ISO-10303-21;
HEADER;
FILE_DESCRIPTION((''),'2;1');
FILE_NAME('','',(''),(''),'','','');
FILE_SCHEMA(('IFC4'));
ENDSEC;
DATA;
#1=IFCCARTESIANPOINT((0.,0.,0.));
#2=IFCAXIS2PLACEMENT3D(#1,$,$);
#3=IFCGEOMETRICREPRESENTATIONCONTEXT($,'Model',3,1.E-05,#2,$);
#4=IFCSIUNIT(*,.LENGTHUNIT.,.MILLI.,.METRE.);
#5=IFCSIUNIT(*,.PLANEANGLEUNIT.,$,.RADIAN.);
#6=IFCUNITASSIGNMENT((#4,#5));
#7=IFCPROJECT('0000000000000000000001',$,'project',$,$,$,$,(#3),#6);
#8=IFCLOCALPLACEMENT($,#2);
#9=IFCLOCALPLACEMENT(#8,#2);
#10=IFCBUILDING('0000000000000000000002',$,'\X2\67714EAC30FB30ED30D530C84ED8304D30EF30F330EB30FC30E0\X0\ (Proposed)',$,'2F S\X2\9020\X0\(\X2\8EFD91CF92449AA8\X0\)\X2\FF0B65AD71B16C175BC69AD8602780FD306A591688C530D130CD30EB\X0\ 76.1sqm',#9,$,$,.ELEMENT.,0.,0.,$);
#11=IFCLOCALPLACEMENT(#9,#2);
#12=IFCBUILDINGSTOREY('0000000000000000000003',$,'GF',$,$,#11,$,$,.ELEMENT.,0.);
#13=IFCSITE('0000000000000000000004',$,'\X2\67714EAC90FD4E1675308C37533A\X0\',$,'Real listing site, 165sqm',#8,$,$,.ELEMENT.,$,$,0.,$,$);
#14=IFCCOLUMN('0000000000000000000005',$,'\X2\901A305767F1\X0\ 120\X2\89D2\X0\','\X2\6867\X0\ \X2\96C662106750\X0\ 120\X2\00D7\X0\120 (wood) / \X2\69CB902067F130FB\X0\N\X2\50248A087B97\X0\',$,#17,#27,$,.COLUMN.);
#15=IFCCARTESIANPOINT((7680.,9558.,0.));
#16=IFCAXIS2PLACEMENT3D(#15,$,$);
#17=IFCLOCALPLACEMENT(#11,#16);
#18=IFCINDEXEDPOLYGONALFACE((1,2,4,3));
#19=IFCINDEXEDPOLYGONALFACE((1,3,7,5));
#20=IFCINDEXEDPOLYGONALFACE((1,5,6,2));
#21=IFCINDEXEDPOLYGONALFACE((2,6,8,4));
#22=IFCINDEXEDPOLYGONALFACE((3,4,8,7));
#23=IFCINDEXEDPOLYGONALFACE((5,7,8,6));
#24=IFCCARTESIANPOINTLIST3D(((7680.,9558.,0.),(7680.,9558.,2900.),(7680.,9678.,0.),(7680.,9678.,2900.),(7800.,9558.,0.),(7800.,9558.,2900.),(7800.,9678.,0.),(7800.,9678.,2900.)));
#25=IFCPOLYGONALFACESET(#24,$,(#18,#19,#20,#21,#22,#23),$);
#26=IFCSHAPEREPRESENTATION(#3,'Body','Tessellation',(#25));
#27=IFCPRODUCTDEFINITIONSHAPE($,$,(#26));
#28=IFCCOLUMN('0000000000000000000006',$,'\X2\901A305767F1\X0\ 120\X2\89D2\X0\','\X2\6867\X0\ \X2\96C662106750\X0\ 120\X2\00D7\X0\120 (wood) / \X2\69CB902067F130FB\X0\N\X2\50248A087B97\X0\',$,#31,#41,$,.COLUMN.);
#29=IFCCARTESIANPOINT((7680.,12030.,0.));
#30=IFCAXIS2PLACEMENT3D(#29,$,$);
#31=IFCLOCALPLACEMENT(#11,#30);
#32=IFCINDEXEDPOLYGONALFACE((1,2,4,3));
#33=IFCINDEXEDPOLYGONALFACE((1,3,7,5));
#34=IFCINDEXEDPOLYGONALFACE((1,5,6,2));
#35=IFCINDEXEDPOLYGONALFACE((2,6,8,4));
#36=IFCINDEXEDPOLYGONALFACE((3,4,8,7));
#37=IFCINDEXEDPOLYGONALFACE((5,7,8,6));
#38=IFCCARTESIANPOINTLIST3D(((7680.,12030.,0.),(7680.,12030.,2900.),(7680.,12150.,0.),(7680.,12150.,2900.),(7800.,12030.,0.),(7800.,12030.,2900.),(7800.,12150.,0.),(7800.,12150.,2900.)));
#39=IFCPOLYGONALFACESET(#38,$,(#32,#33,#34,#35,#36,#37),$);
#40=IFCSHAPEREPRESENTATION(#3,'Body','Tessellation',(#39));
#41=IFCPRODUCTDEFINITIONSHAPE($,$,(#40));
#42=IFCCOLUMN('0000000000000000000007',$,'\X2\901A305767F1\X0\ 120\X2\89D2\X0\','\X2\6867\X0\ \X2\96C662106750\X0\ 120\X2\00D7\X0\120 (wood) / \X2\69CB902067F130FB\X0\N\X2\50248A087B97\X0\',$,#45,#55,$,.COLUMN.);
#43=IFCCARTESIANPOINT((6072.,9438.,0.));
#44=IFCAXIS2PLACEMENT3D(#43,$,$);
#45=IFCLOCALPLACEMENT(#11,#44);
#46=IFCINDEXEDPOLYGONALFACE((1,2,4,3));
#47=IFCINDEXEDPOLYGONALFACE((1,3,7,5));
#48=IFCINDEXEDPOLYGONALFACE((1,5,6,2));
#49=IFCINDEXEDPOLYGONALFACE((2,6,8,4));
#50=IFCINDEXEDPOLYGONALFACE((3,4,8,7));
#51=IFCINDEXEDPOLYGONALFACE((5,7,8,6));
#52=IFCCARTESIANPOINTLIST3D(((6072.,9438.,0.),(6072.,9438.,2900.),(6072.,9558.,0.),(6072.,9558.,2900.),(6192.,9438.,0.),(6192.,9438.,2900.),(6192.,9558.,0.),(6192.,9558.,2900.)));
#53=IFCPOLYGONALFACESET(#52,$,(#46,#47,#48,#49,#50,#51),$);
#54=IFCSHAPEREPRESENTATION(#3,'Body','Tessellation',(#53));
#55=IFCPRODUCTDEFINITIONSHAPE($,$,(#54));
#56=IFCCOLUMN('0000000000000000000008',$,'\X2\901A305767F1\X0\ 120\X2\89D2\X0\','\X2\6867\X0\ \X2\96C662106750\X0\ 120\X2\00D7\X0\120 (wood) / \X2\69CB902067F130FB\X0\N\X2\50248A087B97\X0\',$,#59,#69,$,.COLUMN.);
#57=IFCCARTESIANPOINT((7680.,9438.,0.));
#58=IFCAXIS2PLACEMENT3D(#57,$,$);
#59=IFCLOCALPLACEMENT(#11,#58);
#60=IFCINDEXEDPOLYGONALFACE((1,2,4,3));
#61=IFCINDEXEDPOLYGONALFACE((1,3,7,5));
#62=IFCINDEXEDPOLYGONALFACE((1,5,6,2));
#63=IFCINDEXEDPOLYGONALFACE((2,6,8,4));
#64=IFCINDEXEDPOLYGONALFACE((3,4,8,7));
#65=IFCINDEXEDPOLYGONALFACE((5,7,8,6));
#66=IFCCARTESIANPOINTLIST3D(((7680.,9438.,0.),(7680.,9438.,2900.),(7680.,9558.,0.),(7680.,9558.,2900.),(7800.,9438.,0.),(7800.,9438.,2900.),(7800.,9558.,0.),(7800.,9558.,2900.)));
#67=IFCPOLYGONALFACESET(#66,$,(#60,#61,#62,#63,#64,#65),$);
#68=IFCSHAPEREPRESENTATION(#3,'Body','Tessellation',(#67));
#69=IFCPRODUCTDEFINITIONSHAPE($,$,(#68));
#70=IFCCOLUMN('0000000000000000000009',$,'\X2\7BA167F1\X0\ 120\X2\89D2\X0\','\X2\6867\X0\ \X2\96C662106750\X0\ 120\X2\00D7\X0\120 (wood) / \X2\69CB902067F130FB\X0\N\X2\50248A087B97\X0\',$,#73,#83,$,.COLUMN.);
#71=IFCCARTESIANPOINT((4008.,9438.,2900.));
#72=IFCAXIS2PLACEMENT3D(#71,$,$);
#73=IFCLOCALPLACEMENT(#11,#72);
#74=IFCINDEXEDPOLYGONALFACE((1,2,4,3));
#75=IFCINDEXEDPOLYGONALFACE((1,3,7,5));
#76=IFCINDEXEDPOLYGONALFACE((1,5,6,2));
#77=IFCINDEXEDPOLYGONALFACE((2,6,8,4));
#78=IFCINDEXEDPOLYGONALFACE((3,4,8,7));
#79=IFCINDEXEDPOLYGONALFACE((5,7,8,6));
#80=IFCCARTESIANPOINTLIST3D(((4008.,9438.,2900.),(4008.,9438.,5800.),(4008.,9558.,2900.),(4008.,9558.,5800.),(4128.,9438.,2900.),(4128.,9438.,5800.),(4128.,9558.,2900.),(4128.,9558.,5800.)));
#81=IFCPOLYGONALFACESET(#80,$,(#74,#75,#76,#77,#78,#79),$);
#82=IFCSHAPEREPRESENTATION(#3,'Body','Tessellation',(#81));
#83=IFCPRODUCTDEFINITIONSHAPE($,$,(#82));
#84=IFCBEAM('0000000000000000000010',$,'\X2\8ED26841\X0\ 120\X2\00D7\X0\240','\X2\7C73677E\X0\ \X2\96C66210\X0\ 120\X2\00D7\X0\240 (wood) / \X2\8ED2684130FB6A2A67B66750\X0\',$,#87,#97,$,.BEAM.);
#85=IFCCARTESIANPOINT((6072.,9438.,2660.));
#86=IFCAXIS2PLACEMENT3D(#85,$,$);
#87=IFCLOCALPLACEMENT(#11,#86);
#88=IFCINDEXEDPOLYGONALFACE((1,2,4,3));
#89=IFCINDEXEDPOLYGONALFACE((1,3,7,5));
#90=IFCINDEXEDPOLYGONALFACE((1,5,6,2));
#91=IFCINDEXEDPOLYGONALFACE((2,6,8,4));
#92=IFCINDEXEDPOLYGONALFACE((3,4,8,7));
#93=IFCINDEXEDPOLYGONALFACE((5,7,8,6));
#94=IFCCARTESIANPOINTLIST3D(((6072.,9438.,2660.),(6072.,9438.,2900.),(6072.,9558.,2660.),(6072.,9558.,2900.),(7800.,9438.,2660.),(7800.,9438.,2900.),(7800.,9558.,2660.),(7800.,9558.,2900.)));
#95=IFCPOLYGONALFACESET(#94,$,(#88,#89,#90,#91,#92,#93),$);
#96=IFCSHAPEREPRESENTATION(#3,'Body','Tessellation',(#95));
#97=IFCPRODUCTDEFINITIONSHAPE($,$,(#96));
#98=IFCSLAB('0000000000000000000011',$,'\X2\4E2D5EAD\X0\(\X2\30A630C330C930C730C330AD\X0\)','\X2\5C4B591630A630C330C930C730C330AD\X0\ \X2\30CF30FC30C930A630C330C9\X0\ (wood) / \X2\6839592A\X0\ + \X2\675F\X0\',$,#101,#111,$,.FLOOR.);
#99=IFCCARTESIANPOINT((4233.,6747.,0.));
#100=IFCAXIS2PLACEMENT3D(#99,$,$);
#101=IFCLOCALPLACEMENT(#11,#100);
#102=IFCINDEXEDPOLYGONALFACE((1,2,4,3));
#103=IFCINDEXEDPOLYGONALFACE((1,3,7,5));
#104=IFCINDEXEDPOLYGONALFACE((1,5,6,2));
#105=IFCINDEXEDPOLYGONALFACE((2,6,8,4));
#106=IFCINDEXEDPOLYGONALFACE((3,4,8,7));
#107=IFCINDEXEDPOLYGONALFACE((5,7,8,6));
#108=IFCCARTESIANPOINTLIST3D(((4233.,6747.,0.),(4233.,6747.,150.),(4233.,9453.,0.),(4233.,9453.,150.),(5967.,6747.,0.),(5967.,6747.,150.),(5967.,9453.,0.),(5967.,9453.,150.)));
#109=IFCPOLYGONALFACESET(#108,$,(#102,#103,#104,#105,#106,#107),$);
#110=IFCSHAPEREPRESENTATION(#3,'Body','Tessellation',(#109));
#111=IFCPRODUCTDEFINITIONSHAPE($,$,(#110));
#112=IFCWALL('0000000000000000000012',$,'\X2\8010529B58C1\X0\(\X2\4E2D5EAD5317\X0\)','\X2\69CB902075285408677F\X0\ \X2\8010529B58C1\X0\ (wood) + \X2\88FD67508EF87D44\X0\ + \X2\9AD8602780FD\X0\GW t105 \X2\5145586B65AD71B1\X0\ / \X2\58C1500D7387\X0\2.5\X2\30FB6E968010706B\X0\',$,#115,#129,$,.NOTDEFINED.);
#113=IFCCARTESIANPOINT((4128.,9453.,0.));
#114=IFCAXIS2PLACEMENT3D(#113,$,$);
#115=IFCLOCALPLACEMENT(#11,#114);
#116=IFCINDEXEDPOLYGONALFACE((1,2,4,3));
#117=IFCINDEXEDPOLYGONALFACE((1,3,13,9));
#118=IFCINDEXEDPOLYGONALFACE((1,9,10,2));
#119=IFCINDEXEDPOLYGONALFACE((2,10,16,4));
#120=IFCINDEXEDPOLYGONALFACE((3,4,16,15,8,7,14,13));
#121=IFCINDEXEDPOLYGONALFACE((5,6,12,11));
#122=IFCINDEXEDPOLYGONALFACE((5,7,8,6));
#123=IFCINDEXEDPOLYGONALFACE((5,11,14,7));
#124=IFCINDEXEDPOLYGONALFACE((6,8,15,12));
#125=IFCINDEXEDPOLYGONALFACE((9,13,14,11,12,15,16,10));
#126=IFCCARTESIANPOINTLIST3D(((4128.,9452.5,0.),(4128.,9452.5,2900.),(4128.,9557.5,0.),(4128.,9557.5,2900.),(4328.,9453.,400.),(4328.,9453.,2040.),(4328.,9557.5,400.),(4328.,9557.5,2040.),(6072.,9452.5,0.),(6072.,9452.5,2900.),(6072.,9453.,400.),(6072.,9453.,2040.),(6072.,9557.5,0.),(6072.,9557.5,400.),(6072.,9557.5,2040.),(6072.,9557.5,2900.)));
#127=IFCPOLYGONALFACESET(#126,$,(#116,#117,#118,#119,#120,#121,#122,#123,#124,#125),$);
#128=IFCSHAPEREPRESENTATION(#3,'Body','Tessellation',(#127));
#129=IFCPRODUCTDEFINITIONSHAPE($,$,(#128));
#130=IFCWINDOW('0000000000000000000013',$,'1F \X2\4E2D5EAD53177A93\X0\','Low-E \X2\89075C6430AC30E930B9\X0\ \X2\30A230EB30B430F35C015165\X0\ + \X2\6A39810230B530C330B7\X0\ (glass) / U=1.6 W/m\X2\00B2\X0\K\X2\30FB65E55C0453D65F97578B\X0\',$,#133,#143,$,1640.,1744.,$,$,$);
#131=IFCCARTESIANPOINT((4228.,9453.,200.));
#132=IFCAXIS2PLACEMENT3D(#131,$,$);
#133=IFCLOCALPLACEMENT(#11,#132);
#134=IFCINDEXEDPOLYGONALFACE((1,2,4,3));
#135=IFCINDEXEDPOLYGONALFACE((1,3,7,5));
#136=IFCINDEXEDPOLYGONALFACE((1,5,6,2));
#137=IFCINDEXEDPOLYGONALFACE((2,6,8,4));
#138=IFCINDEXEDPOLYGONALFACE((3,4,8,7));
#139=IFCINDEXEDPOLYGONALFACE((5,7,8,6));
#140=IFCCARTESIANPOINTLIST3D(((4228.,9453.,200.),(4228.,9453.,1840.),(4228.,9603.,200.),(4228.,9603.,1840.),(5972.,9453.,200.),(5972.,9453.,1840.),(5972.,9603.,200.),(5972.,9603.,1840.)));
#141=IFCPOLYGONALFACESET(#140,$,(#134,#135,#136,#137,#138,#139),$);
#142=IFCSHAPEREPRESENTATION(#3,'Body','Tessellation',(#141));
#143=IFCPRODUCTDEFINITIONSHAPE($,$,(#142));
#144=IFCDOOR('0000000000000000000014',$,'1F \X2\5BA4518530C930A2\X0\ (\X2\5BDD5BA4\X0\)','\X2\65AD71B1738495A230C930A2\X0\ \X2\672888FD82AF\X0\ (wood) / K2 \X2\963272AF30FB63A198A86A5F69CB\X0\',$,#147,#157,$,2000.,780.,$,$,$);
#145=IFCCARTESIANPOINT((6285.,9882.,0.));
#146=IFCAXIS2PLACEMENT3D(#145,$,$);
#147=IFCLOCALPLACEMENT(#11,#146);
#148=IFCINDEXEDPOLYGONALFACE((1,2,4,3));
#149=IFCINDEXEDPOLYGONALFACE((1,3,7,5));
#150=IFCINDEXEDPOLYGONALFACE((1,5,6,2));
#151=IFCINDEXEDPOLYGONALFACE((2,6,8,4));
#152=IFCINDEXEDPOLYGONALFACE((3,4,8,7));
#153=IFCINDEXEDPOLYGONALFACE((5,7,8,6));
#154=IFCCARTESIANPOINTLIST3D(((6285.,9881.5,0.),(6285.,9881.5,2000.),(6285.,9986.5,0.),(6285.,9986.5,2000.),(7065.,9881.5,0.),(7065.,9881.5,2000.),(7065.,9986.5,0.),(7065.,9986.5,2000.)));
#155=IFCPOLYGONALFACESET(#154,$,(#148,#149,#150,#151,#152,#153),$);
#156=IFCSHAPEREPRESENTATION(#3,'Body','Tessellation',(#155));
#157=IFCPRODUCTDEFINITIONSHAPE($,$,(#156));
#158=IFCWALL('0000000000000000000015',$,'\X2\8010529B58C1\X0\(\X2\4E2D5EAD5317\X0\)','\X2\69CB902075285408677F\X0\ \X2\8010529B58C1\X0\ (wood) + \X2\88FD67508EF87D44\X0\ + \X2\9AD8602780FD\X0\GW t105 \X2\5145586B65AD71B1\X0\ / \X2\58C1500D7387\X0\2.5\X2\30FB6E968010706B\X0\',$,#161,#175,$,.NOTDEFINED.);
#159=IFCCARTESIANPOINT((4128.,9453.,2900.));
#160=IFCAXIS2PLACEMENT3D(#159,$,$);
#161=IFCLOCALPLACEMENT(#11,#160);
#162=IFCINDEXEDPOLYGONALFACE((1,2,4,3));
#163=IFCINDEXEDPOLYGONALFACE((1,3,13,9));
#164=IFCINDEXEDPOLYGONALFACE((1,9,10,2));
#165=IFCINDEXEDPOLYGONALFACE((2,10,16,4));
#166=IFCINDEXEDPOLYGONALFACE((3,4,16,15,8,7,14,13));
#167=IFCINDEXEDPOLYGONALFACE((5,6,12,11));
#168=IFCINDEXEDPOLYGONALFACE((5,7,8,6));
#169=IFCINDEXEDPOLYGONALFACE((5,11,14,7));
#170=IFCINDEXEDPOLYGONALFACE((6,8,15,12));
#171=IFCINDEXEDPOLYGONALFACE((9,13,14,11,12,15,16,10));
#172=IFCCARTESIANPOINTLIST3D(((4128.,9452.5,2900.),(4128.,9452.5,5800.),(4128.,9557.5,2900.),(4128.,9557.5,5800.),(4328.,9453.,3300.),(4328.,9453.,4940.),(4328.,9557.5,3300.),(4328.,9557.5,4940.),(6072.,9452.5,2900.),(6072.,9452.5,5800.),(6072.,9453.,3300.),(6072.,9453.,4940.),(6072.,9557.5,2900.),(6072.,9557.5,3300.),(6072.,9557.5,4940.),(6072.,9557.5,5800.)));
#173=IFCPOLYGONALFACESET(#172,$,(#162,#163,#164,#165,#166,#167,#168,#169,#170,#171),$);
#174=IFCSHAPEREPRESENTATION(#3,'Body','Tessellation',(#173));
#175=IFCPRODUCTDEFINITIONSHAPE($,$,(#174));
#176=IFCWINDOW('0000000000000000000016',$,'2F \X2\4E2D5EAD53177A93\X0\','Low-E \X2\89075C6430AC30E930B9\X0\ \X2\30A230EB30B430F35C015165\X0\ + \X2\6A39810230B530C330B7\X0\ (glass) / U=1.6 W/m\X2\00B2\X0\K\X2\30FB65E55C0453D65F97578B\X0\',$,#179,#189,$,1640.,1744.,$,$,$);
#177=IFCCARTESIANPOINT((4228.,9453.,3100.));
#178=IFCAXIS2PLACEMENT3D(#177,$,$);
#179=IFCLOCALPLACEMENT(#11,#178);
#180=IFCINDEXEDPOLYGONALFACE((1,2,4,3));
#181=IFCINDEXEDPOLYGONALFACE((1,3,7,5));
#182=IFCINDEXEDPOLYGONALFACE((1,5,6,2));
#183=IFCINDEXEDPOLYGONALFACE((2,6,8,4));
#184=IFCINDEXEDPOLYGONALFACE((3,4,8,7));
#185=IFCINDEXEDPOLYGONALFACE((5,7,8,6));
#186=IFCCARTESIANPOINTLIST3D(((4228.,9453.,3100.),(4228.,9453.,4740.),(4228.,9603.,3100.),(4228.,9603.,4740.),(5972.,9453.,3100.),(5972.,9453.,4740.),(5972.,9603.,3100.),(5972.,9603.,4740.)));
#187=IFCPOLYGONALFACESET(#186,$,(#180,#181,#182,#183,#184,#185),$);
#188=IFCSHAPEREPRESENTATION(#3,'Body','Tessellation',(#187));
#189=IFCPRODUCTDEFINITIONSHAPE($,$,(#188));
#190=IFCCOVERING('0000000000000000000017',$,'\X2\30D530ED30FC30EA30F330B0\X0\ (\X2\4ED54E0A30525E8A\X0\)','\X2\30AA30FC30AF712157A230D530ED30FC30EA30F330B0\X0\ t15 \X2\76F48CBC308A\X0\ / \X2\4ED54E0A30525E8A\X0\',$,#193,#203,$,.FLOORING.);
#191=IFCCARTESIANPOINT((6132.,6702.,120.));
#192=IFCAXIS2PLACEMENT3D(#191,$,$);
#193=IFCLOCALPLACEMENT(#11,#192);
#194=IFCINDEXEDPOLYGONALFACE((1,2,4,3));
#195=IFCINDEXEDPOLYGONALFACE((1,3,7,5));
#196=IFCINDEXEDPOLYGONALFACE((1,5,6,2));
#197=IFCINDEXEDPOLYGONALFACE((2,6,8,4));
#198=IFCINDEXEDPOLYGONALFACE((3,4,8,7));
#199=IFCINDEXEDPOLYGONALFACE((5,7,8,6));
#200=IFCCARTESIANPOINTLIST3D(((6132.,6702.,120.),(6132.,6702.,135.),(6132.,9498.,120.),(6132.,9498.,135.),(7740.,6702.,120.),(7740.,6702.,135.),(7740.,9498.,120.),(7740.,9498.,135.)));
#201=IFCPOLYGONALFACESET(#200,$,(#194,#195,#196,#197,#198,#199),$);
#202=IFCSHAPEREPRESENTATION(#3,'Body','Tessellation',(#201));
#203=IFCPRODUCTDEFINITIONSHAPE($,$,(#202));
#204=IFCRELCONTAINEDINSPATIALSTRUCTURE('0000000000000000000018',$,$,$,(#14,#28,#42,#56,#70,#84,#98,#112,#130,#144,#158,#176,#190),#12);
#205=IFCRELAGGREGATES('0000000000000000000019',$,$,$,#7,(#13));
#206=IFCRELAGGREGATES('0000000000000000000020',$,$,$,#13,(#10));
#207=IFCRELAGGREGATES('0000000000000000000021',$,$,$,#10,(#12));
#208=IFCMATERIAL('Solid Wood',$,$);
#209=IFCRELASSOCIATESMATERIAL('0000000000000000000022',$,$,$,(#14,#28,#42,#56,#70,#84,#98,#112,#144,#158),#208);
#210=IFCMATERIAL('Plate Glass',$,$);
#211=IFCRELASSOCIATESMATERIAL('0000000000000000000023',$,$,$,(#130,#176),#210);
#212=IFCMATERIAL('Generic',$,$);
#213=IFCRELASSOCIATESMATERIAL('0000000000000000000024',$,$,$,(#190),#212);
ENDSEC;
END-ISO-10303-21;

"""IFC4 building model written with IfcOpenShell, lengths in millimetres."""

from ifc_helpers import new_model, si_unit, frame, frame_2d, origin, place, context, project, spatial, rectangle, extrude, material, element, fill, save


model = new_model("IFC4")

# Units and contexts
model_context = context("Model", 3, precision=1e-05, world=origin())
ifc_project = project(units=[si_unit("LENGTHUNIT", "METRE", prefix="MILLI"), si_unit("PLANEANGLEUNIT", "RADIAN")], contexts=[model_context])

# Site, building, storey
site_placement = place(None, origin())
site = spatial("IfcSite", under=ifc_project, at=site_placement, Name="東京都世田谷区", ObjectType="Real listing site, 165sqm", CompositionType="ELEMENT", RefElevation=0.0)
building_placement = place(site_placement, origin())
building = spatial("IfcBuilding", under=site, at=building_placement, Name="東京・ロフト付きワンルーム (Proposed)", ObjectType="2F S造(軽量鉄骨)＋断熱気密高性能な外装パネル 76.1sqm", CompositionType="ELEMENT", ElevationOfRefHeight=0.0, ElevationOfTerrain=0.0)
storey_placement = place(building_placement, origin())
storey = spatial("IfcBuildingStorey", under=building, at=storey_placement, Name="GF", CompositionType="ELEMENT", Elevation=0.0)

# Columns
ifc_material_1 = material(Name="Solid Wood")
column_1_placement = place(storey_placement, frame((7680.0, 9558.0, 0.0)))
element("IfcColumn", 1, at=column_1_placement, inside=storey, material=ifc_material_1, Name="通し柱 120角", Description="桧 集成材 120×120 (wood) / 構造柱・N値計算", PredefinedType="COLUMN", context=model_context, shape_type="SweptSolid", body=[
    extrude(rectangle(XDim=120.0, YDim=120.0, at=frame_2d((60.0, 60.0))), frame((7680.0, 9558.0, 0.0)), (0.0, 0.0, 1.0), 2900.0),
])
column_2_placement = place(storey_placement, frame((7680.0, 12030.0, 0.0)))
element("IfcColumn", 2, at=column_2_placement, inside=storey, material=ifc_material_1, Name="通し柱 120角", Description="桧 集成材 120×120 (wood) / 構造柱・N値計算", PredefinedType="COLUMN", context=model_context, shape_type="SweptSolid", body=[
    extrude(rectangle(XDim=120.0, YDim=120.0, at=frame_2d((60.0, 60.0))), frame((7680.0, 12030.0, 0.0)), (0.0, 0.0, 1.0), 2900.0),
])
column_3_placement = place(storey_placement, frame((6072.0, 9438.0, 0.0)))
element("IfcColumn", 3, at=column_3_placement, inside=storey, material=ifc_material_1, Name="通し柱 120角", Description="桧 集成材 120×120 (wood) / 構造柱・N値計算", PredefinedType="COLUMN", context=model_context, shape_type="SweptSolid", body=[
    extrude(rectangle(XDim=120.0, YDim=120.0, at=frame_2d((60.0, 60.0))), frame((6072.0, 9438.0, 0.0)), (0.0, 0.0, 1.0), 2900.0),
])
column_4_placement = place(storey_placement, frame((7680.0, 9438.0, 0.0)))
element("IfcColumn", 4, at=column_4_placement, inside=storey, material=ifc_material_1, Name="通し柱 120角", Description="桧 集成材 120×120 (wood) / 構造柱・N値計算", PredefinedType="COLUMN", context=model_context, shape_type="SweptSolid", body=[
    extrude(rectangle(XDim=120.0, YDim=120.0, at=frame_2d((60.0, 60.0))), frame((7680.0, 9438.0, 0.0)), (0.0, 0.0, 1.0), 2900.0),
])
column_5_placement = place(storey_placement, frame((4008.0, 9438.0, 2900.0)))
element("IfcColumn", 5, at=column_5_placement, inside=storey, material=ifc_material_1, Name="管柱 120角", Description="桧 集成材 120×120 (wood) / 構造柱・N値計算", PredefinedType="COLUMN", context=model_context, shape_type="SweptSolid", body=[
    extrude(rectangle(XDim=120.0, YDim=120.0, at=frame_2d((60.0, 60.0))), frame((4008.0, 9438.0, 2900.0)), (0.0, 0.0, 1.0), 2900.0),
])

# Beam
beam_1_placement = place(storey_placement, frame((6072.0, 9438.0, 2660.0)))
element("IfcBeam", 6, at=beam_1_placement, inside=storey, material=ifc_material_1, Name="軒桁 120×240", Description="米松 集成 120×240 (wood) / 軒桁・横架材", PredefinedType="BEAM", context=model_context, shape_type="SweptSolid", body=[
    extrude(rectangle(XDim=1728.0, YDim=120.0, at=frame_2d((864.0, 60.0))), frame((6072.0, 9438.0, 2660.0)), (0.0, 0.0, 1.0), 240.0),
])

# Slab
slab_placement = place(storey_placement, frame((4233.0, 6747.0, 0.0)))
element("IfcSlab", 7, at=slab_placement, inside=storey, material=ifc_material_1, Name="中庭(ウッドデッキ)", Description="屋外ウッドデッキ ハードウッド (wood) / 根太 + 束", PredefinedType="FLOOR", context=model_context, shape_type="SweptSolid", body=[
    extrude(rectangle(XDim=1734.0, YDim=2706.0, at=frame_2d((867.0, 1353.0))), frame((4233.0, 6747.0, 0.0)), (0.0, 0.0, 1.0), 150.0),
])

# Wall, opening, window
wall_1_placement = place(storey_placement, frame((4128.0, 9453.0, 0.0)))
wall_1 = element("IfcWall", 8, at=wall_1_placement, inside=storey, material=ifc_material_1, Name="耐力壁(中庭北)", Description="構造用合板 耐力壁 (wood) + 製材軸組 + 高性能GW t105 充填断熱 / 壁倍率2.5・準耐火", PredefinedType="NOTDEFINED", context=model_context, shape_type="SweptSolid", body=[
    extrude(rectangle(XDim=1944.0, YDim=105.0, at=frame_2d((972.0, 52.0))), frame((4128.0, 9453.0, 0.0)), (0.0, 0.0, 1.0), 2900.0),
])
opening_1_placement = place(storey_placement, frame((4228.0, 9453.0, 200.0)))
opening_1 = element("IfcOpeningElement", 9, at=opening_1_placement, cuts=wall_1, PredefinedType="NOTDEFINED", context=model_context, shape_type="SweptSolid", body=[
    extrude(rectangle(XDim=1744.0, YDim=150.0, at=frame_2d((872.0, 75.0))), frame((4228.0, 9453.0, 200.0)), (0.0, 0.0, 1.0), 1640.0),
])
ifc_material_2 = material(Name="Plate Glass")
window_1_placement = place(storey_placement, frame((4228.0, 9453.0, 200.0)))
window_1 = element("IfcWindow", 10, at=window_1_placement, inside=storey, material=ifc_material_2, Name="1F 中庭北窓", Description="Low-E 複層ガラス アルゴン封入 + 樹脂サッシ (glass) / U=1.6 W/m²K・日射取得型", OverallHeight=1640.0, OverallWidth=1744.0, context=model_context, shape_type="SweptSolid", body=[
    extrude(rectangle(XDim=1744.0, YDim=150.0, at=frame_2d((872.0, 75.0))), frame((4228.0, 9453.0, 200.0)), (0.0, 0.0, 1.0), 1640.0),
])
fill(opening_1, window_1)

# Door
door_placement = place(storey_placement, frame((6285.0, 9882.0, 0.0)))
element("IfcDoor", 11, at=door_placement, inside=storey, material=ifc_material_1, Name="1F 室内ドア (寝室)", Description="断熱玄関ドア 木製芯 (wood) / K2 防犯・採風機構", OverallHeight=2000.0, OverallWidth=780.0, context=model_context, shape_type="SweptSolid", body=[
    extrude(rectangle(XDim=780.0, YDim=105.0, at=frame_2d((390.0, 52.0))), frame((6285.0, 9882.0, 0.0)), (0.0, 0.0, 1.0), 2000.0),
])

# Wall, opening, window
wall_2_placement = place(storey_placement, frame((4128.0, 9453.0, 2900.0)))
wall_2 = element("IfcWall", 12, at=wall_2_placement, inside=storey, material=ifc_material_1, Name="耐力壁(中庭北)", Description="構造用合板 耐力壁 (wood) + 製材軸組 + 高性能GW t105 充填断熱 / 壁倍率2.5・準耐火", PredefinedType="NOTDEFINED", context=model_context, shape_type="SweptSolid", body=[
    extrude(rectangle(XDim=1944.0, YDim=105.0, at=frame_2d((972.0, 52.0))), frame((4128.0, 9453.0, 2900.0)), (0.0, 0.0, 1.0), 2900.0),
])
opening_2_placement = place(storey_placement, frame((4228.0, 9453.0, 3100.0)))
opening_2 = element("IfcOpeningElement", 13, at=opening_2_placement, cuts=wall_2, PredefinedType="NOTDEFINED", context=model_context, shape_type="SweptSolid", body=[
    extrude(rectangle(XDim=1744.0, YDim=150.0, at=frame_2d((872.0, 75.0))), frame((4228.0, 9453.0, 3100.0)), (0.0, 0.0, 1.0), 1640.0),
])
window_2_placement = place(storey_placement, frame((4228.0, 9453.0, 3100.0)))
window_2 = element("IfcWindow", 14, at=window_2_placement, inside=storey, material=ifc_material_2, Name="2F 中庭北窓", Description="Low-E 複層ガラス アルゴン封入 + 樹脂サッシ (glass) / U=1.6 W/m²K・日射取得型", OverallHeight=1640.0, OverallWidth=1744.0, context=model_context, shape_type="SweptSolid", body=[
    extrude(rectangle(XDim=1744.0, YDim=150.0, at=frame_2d((872.0, 75.0))), frame((4228.0, 9453.0, 3100.0)), (0.0, 0.0, 1.0), 1640.0),
])
fill(opening_2, window_2)

# Covering
ifc_material_3 = material(Name="Generic")
covering_placement = place(storey_placement, frame((6132.0, 6702.0, 120.0)))
element("IfcCovering", 15, at=covering_placement, inside=storey, material=ifc_material_3, Name="フローリング (仕上げ床)", Description="オーク無垢フローリング t15 直貼り / 仕上げ床", PredefinedType="FLOORING", context=model_context, shape_type="SweptSolid", body=[
    extrude(rectangle(XDim=1608.0, YDim=2796.0, at=frame_2d((804.0, 1398.0))), frame((6132.0, 6702.0, 120.0)), (0.0, 0.0, 1.0), 15.0),
])

save(model, "model.ifc")
